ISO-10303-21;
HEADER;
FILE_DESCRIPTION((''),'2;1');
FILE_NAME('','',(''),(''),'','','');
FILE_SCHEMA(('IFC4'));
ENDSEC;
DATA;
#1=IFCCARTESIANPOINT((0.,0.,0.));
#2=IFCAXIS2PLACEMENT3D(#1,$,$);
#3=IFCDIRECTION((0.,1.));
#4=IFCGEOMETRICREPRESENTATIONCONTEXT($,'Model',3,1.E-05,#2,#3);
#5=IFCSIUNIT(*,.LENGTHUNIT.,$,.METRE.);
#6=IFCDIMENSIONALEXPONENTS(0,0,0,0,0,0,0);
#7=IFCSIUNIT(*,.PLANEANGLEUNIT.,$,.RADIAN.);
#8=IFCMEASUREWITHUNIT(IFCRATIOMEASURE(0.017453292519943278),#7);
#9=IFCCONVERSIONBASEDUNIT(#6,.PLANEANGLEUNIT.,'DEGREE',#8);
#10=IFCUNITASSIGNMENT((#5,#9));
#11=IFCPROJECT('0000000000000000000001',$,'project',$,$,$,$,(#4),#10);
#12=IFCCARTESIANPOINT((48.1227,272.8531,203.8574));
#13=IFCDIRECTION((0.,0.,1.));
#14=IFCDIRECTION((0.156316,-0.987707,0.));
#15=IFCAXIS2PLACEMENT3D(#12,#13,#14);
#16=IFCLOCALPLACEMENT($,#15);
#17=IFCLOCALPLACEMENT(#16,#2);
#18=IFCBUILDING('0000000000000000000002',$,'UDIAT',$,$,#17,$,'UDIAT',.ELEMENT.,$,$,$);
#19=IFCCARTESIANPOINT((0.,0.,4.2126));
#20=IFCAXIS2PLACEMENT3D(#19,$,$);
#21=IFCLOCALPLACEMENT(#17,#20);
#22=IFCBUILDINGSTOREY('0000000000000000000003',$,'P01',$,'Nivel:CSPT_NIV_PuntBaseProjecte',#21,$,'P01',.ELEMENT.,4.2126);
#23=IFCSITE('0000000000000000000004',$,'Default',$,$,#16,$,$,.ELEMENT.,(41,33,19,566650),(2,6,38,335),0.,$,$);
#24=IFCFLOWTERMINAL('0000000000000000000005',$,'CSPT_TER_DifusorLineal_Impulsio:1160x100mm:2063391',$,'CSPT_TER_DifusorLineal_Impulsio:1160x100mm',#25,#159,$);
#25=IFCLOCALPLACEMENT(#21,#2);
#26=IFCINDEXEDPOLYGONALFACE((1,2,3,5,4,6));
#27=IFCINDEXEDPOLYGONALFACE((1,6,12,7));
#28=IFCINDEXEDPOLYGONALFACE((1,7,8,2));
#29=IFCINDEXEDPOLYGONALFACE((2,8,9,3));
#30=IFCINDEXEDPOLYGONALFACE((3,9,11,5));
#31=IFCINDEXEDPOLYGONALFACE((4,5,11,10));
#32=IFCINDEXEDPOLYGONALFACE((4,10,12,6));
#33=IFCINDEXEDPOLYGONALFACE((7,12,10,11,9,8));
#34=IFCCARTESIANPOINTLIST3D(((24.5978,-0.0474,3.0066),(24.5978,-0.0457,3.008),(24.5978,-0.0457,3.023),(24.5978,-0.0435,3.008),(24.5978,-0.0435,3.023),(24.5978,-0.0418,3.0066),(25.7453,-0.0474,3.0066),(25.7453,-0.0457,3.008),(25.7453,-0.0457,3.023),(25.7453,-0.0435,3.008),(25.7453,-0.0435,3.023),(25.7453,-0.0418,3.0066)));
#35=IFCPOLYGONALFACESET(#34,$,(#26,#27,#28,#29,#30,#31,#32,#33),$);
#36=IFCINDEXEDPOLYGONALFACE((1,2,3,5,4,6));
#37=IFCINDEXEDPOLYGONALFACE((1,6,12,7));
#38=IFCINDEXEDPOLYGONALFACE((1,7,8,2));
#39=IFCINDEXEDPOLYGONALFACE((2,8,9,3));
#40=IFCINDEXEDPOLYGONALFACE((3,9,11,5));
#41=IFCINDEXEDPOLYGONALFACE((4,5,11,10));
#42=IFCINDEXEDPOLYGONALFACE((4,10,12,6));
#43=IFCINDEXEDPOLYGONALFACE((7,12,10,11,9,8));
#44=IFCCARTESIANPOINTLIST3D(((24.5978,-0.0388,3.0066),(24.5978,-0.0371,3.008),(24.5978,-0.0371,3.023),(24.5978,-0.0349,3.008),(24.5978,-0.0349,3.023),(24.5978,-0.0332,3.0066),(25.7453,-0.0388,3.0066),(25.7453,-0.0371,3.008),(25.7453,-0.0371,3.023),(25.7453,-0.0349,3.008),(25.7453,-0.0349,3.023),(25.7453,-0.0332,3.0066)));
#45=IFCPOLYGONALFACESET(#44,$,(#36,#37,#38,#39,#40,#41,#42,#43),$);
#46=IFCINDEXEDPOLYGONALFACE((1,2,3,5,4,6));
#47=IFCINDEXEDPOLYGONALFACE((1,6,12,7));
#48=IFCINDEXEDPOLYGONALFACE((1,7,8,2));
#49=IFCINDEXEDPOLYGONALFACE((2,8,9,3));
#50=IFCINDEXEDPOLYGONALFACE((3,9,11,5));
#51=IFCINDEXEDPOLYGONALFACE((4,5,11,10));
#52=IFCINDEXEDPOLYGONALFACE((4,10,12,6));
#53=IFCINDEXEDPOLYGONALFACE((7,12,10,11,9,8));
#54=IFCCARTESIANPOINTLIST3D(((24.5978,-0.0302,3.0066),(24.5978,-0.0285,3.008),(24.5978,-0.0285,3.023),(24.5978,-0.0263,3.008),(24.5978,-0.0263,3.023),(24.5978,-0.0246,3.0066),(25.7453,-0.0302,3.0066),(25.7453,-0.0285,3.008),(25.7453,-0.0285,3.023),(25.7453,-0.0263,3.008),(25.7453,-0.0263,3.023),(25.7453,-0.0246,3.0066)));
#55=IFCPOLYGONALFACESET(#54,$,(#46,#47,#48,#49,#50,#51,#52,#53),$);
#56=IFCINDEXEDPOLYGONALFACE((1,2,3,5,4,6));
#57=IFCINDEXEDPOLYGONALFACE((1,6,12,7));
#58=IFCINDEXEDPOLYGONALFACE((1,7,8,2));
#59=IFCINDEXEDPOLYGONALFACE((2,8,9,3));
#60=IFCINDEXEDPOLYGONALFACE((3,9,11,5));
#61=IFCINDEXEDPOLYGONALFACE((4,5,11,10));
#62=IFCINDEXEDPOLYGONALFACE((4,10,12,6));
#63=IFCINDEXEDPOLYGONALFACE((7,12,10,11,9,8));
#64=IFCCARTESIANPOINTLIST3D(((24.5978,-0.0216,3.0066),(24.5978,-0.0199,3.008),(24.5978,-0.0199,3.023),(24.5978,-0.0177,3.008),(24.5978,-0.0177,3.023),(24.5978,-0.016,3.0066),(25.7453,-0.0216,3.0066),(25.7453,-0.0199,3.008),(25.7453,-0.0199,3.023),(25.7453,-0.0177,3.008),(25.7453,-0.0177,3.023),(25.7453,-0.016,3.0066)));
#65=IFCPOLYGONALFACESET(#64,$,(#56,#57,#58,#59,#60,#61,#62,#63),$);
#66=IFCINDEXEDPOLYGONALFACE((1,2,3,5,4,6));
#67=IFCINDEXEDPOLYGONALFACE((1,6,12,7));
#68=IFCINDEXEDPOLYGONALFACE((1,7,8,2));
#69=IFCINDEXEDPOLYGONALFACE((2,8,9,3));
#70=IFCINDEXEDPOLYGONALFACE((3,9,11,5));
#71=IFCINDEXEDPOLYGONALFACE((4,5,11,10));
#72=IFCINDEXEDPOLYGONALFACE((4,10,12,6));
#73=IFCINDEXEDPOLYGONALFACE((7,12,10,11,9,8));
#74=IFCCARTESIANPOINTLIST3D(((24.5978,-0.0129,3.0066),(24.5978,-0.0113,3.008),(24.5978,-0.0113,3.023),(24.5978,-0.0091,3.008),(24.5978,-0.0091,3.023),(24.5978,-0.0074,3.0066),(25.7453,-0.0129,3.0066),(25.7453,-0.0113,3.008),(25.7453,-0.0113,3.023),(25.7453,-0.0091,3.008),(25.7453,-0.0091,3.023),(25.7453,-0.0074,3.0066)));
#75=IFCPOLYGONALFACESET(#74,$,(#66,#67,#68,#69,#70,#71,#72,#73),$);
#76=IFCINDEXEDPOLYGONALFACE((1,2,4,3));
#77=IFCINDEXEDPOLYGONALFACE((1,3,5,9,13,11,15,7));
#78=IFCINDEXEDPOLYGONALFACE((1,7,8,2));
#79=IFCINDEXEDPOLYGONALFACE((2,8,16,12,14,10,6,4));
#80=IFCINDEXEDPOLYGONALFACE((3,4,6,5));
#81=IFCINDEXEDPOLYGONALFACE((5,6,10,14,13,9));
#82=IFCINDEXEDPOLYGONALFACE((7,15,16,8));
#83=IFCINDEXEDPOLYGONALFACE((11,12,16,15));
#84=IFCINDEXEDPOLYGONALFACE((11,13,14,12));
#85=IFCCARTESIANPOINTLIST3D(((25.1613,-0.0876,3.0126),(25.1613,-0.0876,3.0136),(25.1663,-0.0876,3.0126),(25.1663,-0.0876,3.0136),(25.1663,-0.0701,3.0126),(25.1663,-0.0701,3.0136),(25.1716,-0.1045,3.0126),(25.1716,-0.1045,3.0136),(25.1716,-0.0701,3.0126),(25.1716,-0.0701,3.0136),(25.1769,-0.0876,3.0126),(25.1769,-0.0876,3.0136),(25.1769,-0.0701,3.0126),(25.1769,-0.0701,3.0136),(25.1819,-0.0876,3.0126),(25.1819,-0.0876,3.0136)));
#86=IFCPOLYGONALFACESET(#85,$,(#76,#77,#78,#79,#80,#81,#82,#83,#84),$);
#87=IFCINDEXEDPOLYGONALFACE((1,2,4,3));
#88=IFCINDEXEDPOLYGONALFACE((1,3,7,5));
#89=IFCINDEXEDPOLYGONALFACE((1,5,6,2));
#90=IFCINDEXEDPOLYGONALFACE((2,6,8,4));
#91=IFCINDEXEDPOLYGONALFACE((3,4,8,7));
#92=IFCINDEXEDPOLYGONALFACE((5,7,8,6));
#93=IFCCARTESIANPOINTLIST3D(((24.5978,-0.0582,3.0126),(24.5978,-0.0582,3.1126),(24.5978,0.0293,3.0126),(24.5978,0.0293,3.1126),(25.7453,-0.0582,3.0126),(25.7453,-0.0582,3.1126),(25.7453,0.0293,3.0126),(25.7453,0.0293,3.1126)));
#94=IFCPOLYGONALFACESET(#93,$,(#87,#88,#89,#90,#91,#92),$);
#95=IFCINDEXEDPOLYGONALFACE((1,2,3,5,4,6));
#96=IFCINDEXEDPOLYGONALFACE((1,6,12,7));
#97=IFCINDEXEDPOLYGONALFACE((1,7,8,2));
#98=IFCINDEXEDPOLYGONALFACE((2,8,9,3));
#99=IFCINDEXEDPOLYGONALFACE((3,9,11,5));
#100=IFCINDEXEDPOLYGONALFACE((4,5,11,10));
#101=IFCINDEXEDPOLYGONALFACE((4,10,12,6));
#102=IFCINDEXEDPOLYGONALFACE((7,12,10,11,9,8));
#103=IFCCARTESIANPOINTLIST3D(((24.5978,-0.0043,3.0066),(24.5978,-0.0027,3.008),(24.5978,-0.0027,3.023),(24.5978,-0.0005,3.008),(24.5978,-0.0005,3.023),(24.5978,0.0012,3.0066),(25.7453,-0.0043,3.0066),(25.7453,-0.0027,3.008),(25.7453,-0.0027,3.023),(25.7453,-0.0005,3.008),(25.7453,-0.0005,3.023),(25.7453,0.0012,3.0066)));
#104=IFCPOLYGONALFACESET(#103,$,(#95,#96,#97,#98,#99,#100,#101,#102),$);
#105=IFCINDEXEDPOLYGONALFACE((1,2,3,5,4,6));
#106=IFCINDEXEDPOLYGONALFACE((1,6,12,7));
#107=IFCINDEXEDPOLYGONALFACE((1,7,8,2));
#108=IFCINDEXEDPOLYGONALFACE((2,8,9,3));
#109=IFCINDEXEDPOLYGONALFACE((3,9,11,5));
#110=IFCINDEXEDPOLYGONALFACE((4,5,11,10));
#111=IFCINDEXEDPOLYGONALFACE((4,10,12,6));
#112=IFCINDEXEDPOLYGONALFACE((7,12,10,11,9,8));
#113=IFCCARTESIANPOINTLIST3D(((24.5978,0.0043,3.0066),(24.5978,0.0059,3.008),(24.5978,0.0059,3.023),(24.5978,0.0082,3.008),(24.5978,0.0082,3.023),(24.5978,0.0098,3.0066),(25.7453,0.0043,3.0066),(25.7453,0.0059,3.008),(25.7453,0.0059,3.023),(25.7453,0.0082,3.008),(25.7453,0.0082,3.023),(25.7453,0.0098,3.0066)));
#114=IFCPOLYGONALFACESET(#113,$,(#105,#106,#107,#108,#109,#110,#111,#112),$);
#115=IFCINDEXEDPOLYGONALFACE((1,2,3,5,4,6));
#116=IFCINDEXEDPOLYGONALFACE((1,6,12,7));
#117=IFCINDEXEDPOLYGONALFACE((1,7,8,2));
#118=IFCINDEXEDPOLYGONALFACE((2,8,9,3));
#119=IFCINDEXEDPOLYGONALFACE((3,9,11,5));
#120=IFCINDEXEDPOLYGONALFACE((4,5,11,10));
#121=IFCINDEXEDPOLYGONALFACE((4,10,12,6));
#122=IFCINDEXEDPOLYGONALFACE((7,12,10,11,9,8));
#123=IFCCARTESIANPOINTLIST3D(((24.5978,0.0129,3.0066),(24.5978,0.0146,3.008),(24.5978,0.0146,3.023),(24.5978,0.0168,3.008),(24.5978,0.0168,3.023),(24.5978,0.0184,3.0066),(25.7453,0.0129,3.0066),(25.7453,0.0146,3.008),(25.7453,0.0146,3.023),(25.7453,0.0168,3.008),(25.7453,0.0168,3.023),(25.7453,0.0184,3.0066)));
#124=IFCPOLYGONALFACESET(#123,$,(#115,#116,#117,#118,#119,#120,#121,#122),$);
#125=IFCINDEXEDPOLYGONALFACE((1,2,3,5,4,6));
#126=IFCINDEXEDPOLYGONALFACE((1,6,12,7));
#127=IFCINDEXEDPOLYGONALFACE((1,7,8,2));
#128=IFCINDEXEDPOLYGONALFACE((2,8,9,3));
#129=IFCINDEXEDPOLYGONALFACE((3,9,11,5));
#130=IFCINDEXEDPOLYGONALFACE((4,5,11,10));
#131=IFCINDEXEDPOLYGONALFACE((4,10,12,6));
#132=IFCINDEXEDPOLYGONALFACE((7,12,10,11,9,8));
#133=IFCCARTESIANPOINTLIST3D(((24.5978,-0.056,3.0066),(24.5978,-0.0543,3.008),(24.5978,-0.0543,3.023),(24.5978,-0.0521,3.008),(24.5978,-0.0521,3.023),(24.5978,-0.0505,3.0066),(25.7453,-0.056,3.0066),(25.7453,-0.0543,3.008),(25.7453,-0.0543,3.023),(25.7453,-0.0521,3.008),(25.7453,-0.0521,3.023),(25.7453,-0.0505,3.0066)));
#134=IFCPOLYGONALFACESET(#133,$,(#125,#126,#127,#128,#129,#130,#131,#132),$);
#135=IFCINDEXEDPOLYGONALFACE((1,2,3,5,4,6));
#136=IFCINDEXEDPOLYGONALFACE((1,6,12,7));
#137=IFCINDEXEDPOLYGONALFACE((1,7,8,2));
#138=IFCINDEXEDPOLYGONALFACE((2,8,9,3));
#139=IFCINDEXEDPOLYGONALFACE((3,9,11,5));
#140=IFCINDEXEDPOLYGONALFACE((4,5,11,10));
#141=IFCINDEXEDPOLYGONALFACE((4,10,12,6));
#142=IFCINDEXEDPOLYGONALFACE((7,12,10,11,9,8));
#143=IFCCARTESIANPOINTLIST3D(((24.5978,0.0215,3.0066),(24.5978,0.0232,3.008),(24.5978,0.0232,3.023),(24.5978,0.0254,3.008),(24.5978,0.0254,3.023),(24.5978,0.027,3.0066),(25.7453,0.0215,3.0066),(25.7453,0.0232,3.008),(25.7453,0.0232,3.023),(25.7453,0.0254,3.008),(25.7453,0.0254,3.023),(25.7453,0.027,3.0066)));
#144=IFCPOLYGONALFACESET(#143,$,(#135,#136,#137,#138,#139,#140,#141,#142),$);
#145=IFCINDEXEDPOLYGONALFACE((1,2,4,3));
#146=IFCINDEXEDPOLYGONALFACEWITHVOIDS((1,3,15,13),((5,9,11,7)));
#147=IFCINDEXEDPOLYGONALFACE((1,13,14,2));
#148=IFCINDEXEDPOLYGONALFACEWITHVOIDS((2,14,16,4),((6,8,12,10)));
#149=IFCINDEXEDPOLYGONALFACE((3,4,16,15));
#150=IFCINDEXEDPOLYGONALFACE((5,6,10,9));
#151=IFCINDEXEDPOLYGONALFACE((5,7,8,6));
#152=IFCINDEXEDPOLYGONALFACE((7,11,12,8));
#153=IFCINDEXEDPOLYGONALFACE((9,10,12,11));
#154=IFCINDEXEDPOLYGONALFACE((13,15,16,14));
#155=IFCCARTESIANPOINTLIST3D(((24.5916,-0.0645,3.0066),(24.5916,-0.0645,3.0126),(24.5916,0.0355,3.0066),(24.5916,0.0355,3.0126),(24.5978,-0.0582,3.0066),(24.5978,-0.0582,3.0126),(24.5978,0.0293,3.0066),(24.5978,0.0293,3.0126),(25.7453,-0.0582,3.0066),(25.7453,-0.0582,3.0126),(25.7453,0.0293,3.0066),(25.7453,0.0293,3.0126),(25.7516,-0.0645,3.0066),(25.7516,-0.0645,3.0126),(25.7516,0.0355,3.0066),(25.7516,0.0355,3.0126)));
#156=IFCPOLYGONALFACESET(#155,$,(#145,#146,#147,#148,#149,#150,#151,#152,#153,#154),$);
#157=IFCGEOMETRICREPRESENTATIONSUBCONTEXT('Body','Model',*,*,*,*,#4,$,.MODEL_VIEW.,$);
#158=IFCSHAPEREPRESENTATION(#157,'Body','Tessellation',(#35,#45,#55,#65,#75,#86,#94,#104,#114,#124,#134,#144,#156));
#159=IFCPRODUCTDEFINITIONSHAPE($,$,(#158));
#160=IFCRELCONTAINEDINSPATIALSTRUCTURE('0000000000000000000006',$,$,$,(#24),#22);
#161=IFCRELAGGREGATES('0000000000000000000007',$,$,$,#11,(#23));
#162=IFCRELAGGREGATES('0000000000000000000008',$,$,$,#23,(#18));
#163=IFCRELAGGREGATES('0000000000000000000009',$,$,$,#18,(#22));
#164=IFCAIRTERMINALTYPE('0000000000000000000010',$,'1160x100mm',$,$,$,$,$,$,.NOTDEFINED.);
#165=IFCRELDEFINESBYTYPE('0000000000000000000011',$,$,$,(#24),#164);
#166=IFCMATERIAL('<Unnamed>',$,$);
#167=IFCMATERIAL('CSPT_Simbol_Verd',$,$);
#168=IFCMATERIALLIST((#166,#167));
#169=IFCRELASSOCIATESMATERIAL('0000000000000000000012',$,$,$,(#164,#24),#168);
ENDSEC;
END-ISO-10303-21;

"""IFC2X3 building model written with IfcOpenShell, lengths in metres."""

from ifc_helpers import new_model, entity, si_unit, converted_unit, direction, frame, origin, origin_2d_with_axis, place, context, subcontext, project, spatial, polyline, rectangle, outline, extrude, source, transform, mapped, material, material_list, type_object, type_shapes, element, save


model = new_model("IFC2X3")

# Units and contexts
model_context = context("Model", 3, precision=1e-05, world=origin(), true_north=direction((0.0, 1.0)))
body_context = subcontext(model_context, "Body", "Model", "MODEL_VIEW")
ifc_project = project(units=[si_unit("LENGTHUNIT", "METRE"), converted_unit("PLANEANGLEUNIT", "DEGREE", entity("IfcRatioMeasure", 0.017453292519943278), si_unit("PLANEANGLEUNIT", "RADIAN"), dimensions=[0, 0, 0, 0, 0, 0, 0])], contexts=[model_context])

# Site, building, storey
site_placement = place(None, frame((48.1227, 272.8531, 203.8574), z_axis=(0.0, 0.0, 1.0), x_axis=(0.156316, -0.987707, 0.0)))
site = spatial("IfcSite", under=ifc_project, at=site_placement, Name="Default", CompositionType="ELEMENT", RefLatitude=(41, 33, 19, 566650), RefLongitude=(2, 6, 38, 335), RefElevation=0.0)
building_placement = place(site_placement, origin())
building = spatial("IfcBuilding", under=site, at=building_placement, Name="UDIAT", LongName="UDIAT", CompositionType="ELEMENT")
storey_placement = place(building_placement, frame((0.0, 0.0, 4.2126)))
storey = spatial("IfcBuildingStorey", under=building, at=storey_placement, Name="P01", ObjectType="Nivel:CSPT_NIV_PuntBaseProjecte", LongName="P01", CompositionType="ELEMENT", Elevation=4.2126)

# Shared definitions
ifc_material_1 = material(Name="<Unnamed>")

# Flow terminal
ifc_material_2 = material(Name="CSPT_Simbol_Verd")
ifc_material_list = material_list([ifc_material_1, ifc_material_2])
air_terminal_type = type_object("IfcAirTerminalType", Name="1160x100mm", PredefinedType="NOTDEFINED", material=ifc_material_list)
shared_shape_1 = source(origin(), body_context, "Body", "SweptSolid", [
    extrude(outline(polyline([(0.0037, 0.0028), (0.0059, 0.0028), (0.0016, 0.0063), (0.002, 0.0042), (-0.0074, -0.0074), (-0.0057, -0.0088), (0.0037, 0.0028)])), frame((-0.5737, 0.0301, -0.0001), z_axis=(1.0, 0.0, 0.0), x_axis=(0.0, -0.776119, -0.630587)), (0.0, 0.0, 1.0), 1.1475),
    extrude(outline(polyline([(0.0037, 0.0028), (0.0059, 0.0028), (0.0016, 0.0063), (0.002, 0.0042), (-0.0074, -0.0074), (-0.0057, -0.0088), (0.0037, 0.0028)])), frame((-0.5737, 0.0215, -0.0001), z_axis=(1.0, 0.0, 0.0), x_axis=(0.0, -0.776119, -0.630587)), (0.0, 0.0, 1.0), 1.1475),
    extrude(outline(polyline([(0.0037, 0.0028), (0.0059, 0.0028), (0.0016, 0.0063), (0.002, 0.0042), (-0.0074, -0.0074), (-0.0057, -0.0088), (0.0037, 0.0028)])), frame((-0.5737, 0.0129, -0.0001), z_axis=(1.0, 0.0, 0.0), x_axis=(0.0, -0.776119, -0.630587)), (0.0, 0.0, 1.0), 1.1475),
    extrude(outline(polyline([(0.0037, 0.0028), (0.0059, 0.0028), (0.0016, 0.0063), (0.002, 0.0042), (-0.0074, -0.0074), (-0.0057, -0.0088), (0.0037, 0.0028)])), frame((-0.5737, 0.0043, -0.0001), z_axis=(1.0, 0.0, 0.0), x_axis=(0.0, -0.776119, -0.630587)), (0.0, 0.0, 1.0), 1.1475),
    extrude(outline(polyline([(0.0037, 0.0028), (0.0059, 0.0028), (0.0016, 0.0063), (0.002, 0.0042), (-0.0074, -0.0074), (-0.0057, -0.0088), (0.0037, 0.0028)])), frame((-0.5737, -0.0043, -0.0001), z_axis=(1.0, 0.0, 0.0), x_axis=(0.0, -0.776119, -0.630587)), (0.0, 0.0, 1.0), 1.1475),
    extrude(outline(polyline([(0.0, -0.013), (0.0053, -0.013), (0.0053, 0.0045), (0.0103, 0.0045), (0.0, 0.0213), (-0.0103, 0.0045), (-0.0053, 0.0045), (-0.0053, -0.013), (0.0, -0.013)])), frame((0.0, 0.0687, 0.0)), (0.0, 0.0, 1.0), 0.001),
    extrude(rectangle(XDim=1.1475, YDim=0.0875, at=origin_2d_with_axis()), frame((0.0, 0.0, 0.0), z_axis=(0.0, 0.0, 1.0), x_axis=(-1.0, 0.0, 0.0)), (0.0, 0.0, 1.0), 0.1),
    extrude(outline(polyline([(0.0037, 0.0028), (0.0059, 0.0028), (0.0016, 0.0063), (0.002, 0.0042), (-0.0074, -0.0074), (-0.0057, -0.0088), (0.0037, 0.0028)])), frame((-0.5737, -0.0129, -0.0001), z_axis=(1.0, 0.0, 0.0), x_axis=(0.0, -0.776119, -0.630587)), (0.0, 0.0, 1.0), 1.1475),
    extrude(outline(polyline([(0.0037, 0.0028), (0.0059, 0.0028), (0.0016, 0.0063), (0.002, 0.0042), (-0.0074, -0.0074), (-0.0057, -0.0088), (0.0037, 0.0028)])), frame((-0.5737, -0.0215, -0.0001), z_axis=(1.0, 0.0, 0.0), x_axis=(0.0, -0.776119, -0.630587)), (0.0, 0.0, 1.0), 1.1475),
    extrude(outline(polyline([(0.0037, 0.0028), (0.0059, 0.0028), (0.0016, 0.0063), (0.002, 0.0042), (-0.0074, -0.0074), (-0.0057, -0.0088), (0.0037, 0.0028)])), frame((-0.5737, -0.0301, -0.0001), z_axis=(1.0, 0.0, 0.0), x_axis=(0.0, -0.776119, -0.630587)), (0.0, 0.0, 1.0), 1.1475),
    extrude(outline(polyline([(0.0037, 0.0028), (0.0059, 0.0028), (0.0016, 0.0063), (0.002, 0.0042), (-0.0074, -0.0074), (-0.0057, -0.0088), (0.0037, 0.0028)])), frame((-0.5737, 0.0388, -0.0001), z_axis=(1.0, 0.0, 0.0), x_axis=(0.0, -0.776119, -0.630587)), (0.0, 0.0, 1.0), 1.1475),
    extrude(outline(polyline([(0.0037, 0.0028), (0.0059, 0.0028), (0.0016, 0.0063), (0.002, 0.0042), (-0.0074, -0.0074), (-0.0057, -0.0088), (0.0037, 0.0028)])), frame((-0.5737, -0.0387, -0.0001), z_axis=(1.0, 0.0, 0.0), x_axis=(0.0, -0.776119, -0.630587)), (0.0, 0.0, 1.0), 1.1475),
    extrude(outline(polyline([(-0.58, -0.05), (0.58, -0.05), (0.58, 0.05), (-0.58, 0.05), (-0.58, -0.05)]), holes=[polyline([(-0.5738, -0.0438), (-0.5738, 0.0437), (0.5737, 0.0437), (0.5737, -0.0438), (-0.5738, -0.0438)])]), frame((0.0, 0.0, -0.006), z_axis=(0.0, 0.0, 1.0), x_axis=(-1.0, 0.0, 0.0)), (0.0, 0.0, 1.0), 0.006),
])
type_shapes(air_terminal_type, [shared_shape_1])
for number, where, z_axis, x_axis, name in (
    (1, (25.1716, -0.0145, 3.0126), (0.0, 0.0, 1.0), (-1.0, 0.0, 0.0), "CSPT_TER_DifusorLineal_Impulsio:1160x100mm:2063391"),
):
    element("IfcFlowTerminal", number, at=place(storey_placement, frame(where, z_axis=z_axis, x_axis=x_axis)), inside=storey, type_object=air_terminal_type, material=ifc_material_list, Name=name, ObjectType="CSPT_TER_DifusorLineal_Impulsio:1160x100mm", context=body_context, shape_type="MappedRepresentation", body=[
        mapped(shared_shape_1, transform((0.0, 0.0, 0.0), scale=1.0)),
    ])

save(model, "model.ifc")
